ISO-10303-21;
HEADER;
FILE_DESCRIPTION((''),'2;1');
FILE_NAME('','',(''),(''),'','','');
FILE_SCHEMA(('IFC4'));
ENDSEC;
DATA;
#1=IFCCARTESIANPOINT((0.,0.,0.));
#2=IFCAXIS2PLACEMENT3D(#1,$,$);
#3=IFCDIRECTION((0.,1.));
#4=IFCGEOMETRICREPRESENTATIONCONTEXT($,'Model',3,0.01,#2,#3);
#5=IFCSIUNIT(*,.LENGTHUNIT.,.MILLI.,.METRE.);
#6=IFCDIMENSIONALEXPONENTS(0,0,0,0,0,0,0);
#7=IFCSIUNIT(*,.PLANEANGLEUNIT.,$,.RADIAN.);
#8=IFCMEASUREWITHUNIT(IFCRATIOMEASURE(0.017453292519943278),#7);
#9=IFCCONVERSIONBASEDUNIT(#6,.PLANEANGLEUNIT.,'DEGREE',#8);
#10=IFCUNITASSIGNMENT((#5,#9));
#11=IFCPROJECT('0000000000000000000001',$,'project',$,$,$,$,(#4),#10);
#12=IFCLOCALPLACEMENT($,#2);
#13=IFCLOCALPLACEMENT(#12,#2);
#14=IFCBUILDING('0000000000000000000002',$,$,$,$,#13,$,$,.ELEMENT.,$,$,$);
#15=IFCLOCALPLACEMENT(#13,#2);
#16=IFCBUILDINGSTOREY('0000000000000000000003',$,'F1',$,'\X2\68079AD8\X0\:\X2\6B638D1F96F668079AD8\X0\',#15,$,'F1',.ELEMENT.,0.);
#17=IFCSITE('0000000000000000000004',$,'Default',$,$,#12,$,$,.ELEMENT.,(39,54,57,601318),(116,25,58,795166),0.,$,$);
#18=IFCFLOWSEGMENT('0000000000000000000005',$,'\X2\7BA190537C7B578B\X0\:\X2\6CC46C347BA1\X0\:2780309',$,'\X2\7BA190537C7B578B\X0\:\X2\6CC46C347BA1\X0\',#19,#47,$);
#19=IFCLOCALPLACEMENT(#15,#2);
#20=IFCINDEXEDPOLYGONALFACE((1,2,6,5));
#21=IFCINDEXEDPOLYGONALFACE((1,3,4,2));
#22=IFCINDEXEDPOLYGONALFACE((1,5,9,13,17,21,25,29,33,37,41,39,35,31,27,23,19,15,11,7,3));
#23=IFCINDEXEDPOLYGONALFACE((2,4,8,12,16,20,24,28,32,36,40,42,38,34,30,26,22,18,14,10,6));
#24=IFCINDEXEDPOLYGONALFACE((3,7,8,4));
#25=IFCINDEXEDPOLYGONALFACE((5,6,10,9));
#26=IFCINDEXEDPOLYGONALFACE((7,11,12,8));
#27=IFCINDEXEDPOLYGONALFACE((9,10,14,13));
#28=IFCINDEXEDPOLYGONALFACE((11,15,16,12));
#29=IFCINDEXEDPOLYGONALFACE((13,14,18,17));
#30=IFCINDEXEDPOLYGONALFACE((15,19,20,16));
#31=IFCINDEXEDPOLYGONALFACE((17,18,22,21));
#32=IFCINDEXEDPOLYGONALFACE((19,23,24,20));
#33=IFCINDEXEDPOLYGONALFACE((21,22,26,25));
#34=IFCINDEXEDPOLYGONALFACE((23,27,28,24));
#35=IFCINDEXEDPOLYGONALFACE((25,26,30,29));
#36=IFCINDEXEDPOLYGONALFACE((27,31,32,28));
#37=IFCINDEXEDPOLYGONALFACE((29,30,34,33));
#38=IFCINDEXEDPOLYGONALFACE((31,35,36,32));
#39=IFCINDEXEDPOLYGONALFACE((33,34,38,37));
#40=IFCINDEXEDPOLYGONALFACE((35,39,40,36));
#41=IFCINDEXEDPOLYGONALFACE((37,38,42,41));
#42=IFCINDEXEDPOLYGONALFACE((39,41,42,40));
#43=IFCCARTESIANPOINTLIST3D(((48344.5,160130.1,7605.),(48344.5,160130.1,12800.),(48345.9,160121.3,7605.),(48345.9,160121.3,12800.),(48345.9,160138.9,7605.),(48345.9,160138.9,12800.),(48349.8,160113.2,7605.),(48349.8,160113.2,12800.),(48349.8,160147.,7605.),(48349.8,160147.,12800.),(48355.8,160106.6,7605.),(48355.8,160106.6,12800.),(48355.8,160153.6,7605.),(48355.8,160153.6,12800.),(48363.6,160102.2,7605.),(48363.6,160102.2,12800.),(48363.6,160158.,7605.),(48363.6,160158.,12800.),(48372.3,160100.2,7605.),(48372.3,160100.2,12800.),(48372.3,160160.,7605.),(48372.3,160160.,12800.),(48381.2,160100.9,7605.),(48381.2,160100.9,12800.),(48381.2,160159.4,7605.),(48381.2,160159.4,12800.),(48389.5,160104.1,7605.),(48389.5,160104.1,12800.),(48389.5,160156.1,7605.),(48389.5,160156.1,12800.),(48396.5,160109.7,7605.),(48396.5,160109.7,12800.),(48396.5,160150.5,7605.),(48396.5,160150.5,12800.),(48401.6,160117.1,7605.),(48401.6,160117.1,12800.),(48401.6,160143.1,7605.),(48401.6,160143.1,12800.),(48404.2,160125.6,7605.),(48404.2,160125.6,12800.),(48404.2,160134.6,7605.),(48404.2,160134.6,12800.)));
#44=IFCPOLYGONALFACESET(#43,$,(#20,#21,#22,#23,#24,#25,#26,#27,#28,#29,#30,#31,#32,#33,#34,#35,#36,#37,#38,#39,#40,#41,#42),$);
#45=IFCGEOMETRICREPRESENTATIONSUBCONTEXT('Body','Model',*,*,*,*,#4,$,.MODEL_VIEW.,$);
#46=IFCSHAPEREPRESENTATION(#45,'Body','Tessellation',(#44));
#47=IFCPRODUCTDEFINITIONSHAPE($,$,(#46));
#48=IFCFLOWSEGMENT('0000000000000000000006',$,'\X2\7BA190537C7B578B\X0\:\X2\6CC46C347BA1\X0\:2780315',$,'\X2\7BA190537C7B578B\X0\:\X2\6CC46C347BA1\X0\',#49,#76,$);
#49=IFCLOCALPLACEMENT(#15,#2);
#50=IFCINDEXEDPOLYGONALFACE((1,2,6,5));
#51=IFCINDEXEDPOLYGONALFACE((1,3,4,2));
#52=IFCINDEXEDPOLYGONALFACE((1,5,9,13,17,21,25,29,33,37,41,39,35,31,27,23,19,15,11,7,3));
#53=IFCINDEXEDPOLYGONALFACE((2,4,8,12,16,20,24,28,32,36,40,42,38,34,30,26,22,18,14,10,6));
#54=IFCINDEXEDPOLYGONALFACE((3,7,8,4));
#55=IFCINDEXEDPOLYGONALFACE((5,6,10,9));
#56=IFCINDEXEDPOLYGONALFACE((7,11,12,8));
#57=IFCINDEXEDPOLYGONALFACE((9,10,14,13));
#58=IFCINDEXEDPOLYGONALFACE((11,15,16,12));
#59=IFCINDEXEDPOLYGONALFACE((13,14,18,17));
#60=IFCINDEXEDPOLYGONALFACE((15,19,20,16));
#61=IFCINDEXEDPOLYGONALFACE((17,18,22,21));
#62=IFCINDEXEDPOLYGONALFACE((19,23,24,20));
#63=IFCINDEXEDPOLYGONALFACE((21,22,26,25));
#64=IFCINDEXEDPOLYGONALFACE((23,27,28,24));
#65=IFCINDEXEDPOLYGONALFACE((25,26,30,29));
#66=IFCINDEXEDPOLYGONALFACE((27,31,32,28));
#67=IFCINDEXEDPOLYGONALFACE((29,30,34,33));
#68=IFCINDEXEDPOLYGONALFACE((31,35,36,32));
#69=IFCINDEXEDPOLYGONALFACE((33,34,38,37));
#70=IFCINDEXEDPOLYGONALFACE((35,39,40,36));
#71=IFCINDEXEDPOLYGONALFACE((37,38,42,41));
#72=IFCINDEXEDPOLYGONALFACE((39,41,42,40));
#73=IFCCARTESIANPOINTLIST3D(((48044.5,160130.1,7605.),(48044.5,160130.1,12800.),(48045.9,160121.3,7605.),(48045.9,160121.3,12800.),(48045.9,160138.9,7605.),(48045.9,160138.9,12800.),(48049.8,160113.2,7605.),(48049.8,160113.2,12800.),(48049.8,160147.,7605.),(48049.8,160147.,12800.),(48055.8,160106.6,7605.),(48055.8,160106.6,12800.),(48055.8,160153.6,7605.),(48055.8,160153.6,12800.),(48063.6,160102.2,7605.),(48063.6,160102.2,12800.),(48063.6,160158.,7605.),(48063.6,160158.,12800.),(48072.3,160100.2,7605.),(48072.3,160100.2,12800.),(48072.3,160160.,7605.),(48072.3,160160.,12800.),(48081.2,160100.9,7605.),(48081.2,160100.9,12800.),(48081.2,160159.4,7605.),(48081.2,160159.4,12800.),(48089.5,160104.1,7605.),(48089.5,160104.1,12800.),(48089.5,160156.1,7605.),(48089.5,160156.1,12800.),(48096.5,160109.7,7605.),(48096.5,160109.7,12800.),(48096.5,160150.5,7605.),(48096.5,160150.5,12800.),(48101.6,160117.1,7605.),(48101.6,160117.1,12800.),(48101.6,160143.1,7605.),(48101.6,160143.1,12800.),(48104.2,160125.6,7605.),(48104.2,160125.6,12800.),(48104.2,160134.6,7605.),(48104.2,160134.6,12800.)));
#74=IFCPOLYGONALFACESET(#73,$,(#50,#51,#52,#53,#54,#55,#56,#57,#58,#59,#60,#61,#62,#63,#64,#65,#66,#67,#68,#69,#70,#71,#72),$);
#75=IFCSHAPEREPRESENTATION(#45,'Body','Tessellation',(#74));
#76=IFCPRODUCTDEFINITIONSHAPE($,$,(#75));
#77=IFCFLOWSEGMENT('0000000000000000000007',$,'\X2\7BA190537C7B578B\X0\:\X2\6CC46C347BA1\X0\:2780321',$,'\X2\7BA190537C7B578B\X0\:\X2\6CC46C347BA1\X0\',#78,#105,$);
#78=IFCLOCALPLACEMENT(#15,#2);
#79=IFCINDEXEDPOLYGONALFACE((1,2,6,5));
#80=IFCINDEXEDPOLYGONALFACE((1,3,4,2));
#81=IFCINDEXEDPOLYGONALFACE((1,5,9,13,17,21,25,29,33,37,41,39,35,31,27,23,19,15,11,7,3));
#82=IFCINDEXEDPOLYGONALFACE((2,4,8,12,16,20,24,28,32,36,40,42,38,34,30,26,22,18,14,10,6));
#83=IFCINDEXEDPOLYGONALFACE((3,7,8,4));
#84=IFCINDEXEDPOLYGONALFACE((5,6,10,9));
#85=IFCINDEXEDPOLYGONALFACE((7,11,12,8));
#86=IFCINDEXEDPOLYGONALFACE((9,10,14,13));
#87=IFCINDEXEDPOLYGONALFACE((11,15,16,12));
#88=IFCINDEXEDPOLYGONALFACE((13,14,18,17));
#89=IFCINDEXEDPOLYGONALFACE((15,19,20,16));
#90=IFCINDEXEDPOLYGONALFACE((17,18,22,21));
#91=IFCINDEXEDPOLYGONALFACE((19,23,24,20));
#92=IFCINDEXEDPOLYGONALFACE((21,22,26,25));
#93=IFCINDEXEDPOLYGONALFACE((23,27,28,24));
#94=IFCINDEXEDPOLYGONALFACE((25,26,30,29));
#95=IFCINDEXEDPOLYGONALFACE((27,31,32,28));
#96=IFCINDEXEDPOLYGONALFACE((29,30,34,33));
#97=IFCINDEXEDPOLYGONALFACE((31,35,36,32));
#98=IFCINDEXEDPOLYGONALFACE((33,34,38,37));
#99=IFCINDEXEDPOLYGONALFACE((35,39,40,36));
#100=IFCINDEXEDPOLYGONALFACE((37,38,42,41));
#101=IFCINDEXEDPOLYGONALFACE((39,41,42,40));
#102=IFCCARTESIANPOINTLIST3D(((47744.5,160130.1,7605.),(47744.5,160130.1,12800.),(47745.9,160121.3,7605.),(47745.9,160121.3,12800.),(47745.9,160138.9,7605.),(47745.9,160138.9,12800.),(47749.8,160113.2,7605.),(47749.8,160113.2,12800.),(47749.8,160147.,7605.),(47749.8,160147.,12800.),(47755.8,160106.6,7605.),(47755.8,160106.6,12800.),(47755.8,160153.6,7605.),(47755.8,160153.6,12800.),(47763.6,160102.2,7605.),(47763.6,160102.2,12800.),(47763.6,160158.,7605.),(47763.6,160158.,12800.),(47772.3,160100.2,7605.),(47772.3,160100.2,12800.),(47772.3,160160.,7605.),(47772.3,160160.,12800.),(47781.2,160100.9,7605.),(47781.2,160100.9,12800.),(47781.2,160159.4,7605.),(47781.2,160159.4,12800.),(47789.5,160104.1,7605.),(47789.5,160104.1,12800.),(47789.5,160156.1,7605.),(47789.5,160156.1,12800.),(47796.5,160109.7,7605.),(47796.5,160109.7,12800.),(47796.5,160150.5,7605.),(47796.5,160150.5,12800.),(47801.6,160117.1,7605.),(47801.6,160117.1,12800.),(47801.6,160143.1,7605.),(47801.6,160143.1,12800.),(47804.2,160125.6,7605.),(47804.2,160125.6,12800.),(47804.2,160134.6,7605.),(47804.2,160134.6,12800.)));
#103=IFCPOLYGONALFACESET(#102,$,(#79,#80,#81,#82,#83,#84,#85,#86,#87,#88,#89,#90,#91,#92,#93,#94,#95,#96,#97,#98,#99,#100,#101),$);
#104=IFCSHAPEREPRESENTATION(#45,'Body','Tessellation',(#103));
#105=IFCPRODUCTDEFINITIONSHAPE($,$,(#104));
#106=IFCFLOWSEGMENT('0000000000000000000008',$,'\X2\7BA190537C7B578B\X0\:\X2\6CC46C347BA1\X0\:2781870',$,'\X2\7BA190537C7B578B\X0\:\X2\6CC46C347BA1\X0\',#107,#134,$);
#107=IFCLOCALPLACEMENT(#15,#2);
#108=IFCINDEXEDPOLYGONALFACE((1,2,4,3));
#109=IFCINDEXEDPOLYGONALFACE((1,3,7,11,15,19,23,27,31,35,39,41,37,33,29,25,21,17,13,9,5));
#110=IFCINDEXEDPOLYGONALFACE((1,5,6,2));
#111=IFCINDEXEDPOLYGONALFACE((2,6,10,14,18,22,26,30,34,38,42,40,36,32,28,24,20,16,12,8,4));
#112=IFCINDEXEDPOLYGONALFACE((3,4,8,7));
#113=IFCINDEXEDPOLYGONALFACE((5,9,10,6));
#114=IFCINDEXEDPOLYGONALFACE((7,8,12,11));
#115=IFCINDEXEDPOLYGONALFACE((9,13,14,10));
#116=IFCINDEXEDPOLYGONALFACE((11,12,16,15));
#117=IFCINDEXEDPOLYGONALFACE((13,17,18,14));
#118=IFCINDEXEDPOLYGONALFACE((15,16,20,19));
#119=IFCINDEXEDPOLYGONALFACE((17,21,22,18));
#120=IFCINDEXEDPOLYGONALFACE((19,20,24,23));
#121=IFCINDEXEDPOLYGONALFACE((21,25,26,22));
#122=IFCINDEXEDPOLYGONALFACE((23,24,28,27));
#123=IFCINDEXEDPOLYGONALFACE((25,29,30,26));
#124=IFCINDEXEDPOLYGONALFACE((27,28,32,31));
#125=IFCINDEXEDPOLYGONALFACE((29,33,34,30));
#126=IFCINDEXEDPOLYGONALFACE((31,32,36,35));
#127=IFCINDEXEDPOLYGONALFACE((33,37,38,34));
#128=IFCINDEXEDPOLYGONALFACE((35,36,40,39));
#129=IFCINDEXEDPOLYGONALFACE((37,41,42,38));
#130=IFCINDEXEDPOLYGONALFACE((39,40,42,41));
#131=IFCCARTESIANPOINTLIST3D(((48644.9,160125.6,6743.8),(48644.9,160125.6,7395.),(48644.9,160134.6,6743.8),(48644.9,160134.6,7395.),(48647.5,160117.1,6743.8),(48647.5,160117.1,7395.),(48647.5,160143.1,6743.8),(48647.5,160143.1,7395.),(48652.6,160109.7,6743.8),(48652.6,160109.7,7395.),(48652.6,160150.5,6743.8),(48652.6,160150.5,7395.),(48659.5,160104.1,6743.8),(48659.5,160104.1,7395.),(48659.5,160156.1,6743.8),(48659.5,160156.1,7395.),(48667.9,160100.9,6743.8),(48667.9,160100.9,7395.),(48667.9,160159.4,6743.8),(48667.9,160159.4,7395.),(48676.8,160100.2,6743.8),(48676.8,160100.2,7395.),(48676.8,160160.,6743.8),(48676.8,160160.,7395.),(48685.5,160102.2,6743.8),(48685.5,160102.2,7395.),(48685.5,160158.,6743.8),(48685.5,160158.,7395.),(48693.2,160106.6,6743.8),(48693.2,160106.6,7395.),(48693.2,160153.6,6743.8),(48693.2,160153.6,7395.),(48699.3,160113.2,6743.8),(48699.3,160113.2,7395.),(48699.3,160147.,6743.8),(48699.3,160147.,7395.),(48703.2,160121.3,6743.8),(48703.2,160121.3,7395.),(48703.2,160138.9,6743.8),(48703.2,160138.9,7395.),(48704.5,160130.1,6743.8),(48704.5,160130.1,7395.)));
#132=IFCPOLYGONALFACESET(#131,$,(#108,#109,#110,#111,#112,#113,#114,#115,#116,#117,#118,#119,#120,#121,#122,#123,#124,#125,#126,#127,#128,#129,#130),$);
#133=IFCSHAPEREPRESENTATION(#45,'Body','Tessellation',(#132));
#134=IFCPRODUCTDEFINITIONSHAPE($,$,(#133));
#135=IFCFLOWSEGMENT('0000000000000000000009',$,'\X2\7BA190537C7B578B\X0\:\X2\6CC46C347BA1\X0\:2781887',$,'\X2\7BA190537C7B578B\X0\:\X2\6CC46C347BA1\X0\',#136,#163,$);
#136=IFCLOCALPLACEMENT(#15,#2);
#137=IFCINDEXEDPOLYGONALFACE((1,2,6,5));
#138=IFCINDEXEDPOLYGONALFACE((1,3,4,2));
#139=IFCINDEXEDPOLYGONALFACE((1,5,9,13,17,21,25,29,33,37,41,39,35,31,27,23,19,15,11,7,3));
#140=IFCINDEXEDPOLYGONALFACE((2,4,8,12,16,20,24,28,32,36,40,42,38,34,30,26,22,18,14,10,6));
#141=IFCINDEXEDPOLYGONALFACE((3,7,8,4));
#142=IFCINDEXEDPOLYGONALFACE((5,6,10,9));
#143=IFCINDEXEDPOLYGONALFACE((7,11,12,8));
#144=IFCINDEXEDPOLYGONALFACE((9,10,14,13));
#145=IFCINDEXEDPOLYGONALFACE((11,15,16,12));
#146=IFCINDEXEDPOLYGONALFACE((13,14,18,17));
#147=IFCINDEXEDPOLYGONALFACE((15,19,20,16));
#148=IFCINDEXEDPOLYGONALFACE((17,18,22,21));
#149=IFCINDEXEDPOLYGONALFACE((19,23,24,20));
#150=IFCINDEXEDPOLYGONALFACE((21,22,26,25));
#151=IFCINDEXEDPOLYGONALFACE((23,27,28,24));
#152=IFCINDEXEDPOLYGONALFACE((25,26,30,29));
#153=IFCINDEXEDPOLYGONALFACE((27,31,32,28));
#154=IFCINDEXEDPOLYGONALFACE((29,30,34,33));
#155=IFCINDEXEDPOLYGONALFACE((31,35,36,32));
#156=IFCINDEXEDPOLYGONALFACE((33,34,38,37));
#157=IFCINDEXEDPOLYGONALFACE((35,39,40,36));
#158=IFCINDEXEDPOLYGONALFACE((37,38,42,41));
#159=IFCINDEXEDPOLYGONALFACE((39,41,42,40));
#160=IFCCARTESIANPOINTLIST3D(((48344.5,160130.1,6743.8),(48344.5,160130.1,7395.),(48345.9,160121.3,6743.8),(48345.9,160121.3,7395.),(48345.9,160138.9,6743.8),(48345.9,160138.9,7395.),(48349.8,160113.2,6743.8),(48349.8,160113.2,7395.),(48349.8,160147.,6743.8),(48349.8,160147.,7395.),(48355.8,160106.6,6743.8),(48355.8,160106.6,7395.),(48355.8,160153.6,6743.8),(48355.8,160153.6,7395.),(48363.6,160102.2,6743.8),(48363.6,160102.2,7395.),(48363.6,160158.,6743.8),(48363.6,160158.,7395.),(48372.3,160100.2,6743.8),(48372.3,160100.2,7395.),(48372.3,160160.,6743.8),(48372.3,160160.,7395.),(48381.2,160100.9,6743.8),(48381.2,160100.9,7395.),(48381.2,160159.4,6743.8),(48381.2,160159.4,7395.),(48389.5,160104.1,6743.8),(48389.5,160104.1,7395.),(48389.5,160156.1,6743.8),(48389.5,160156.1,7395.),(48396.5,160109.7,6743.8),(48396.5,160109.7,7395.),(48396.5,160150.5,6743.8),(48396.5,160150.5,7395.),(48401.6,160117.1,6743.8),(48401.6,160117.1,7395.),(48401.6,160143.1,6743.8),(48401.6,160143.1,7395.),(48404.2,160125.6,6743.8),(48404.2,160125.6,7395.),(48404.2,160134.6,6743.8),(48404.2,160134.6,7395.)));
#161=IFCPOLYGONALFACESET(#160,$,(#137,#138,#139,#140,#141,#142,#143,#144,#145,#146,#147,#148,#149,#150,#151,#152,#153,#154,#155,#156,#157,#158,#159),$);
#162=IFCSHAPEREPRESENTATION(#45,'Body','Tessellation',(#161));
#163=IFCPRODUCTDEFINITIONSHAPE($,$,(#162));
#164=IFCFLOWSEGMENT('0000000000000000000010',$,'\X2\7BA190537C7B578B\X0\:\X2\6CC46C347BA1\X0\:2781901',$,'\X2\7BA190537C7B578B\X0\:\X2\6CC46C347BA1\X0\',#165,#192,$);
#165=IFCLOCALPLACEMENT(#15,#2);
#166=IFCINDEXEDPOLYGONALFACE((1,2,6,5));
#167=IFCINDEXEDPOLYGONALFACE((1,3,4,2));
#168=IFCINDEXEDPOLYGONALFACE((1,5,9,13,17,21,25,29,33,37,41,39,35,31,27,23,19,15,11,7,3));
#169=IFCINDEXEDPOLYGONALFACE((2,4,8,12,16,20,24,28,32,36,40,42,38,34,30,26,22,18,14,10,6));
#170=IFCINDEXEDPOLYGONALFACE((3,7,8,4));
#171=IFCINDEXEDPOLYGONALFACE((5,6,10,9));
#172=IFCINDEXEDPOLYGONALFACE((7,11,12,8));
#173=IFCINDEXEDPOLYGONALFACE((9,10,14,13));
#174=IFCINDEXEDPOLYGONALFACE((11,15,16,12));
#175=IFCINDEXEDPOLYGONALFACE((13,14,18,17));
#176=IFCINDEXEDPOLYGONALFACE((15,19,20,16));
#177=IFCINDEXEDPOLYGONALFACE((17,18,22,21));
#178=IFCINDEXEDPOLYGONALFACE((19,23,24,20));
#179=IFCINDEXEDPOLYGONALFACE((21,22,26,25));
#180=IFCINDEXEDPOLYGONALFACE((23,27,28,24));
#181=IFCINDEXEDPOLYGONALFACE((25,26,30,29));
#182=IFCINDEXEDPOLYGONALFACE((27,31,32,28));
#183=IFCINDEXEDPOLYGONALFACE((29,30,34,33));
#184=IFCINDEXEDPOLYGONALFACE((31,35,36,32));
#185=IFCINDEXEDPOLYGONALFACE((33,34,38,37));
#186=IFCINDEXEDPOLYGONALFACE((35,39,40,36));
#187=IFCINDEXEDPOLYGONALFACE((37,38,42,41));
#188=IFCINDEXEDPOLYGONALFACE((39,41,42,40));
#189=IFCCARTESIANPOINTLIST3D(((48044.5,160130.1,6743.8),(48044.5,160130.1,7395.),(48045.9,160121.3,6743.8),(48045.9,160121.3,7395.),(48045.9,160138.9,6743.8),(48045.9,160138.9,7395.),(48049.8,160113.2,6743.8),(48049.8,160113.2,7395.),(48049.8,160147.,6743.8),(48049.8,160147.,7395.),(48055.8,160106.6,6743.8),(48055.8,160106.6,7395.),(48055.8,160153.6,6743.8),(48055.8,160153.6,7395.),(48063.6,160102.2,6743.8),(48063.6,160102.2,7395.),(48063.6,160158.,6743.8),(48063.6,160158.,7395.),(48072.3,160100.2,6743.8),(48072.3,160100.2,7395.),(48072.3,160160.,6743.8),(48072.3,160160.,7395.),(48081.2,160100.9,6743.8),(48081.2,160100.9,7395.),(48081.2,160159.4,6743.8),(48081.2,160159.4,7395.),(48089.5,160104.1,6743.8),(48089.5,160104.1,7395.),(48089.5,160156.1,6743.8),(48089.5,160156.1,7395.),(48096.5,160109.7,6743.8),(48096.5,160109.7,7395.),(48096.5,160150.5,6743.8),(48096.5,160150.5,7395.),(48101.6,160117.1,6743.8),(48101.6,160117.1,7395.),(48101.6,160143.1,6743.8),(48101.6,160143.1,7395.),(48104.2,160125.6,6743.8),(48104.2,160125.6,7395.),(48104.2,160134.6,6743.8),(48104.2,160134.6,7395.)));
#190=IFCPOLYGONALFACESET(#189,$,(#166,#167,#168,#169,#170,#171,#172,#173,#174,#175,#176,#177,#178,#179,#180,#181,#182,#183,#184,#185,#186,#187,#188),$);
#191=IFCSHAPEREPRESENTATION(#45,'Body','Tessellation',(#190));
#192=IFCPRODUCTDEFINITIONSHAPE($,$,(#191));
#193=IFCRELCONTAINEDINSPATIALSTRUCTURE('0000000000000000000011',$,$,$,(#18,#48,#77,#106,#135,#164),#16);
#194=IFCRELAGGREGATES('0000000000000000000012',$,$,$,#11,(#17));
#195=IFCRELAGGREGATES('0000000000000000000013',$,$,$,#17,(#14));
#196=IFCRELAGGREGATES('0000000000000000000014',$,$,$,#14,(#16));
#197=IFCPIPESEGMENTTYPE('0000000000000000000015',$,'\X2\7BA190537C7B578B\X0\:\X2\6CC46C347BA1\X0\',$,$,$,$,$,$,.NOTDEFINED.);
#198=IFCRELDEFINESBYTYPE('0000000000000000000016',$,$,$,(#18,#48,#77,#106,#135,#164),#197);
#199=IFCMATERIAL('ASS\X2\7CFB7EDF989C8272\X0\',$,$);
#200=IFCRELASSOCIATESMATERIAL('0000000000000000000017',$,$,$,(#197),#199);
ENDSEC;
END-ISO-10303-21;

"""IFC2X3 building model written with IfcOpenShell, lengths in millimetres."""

from ifc_helpers import new_model, entity, si_unit, converted_unit, direction, frame, frame_2d, origin, origin_2d_with_axis, place, context, subcontext, project, spatial, circle, extrude, material, type_object, element, save


model = new_model("IFC2X3")

# Units and contexts
model_context = context("Model", 3, precision=0.01, world=origin(), true_north=direction((0.0, 1.0)))
body_context = subcontext(model_context, "Body", "Model", "MODEL_VIEW")
ifc_project = project(units=[si_unit("LENGTHUNIT", "METRE", prefix="MILLI"), converted_unit("PLANEANGLEUNIT", "DEGREE", entity("IfcRatioMeasure", 0.017453292519943278), si_unit("PLANEANGLEUNIT", "RADIAN"), dimensions=[0, 0, 0, 0, 0, 0, 0])], contexts=[model_context])

# Site, building, storey
site_placement = place(None, origin())
site = spatial("IfcSite", under=ifc_project, at=site_placement, Name="Default", CompositionType="ELEMENT", RefLatitude=(39, 54, 57, 601318), RefLongitude=(116, 25, 58, 795166), RefElevation=0.0)
building_placement = place(site_placement, origin())
building = spatial("IfcBuilding", under=site, at=building_placement, CompositionType="ELEMENT")
storey_placement = place(building_placement, origin())
storey = spatial("IfcBuildingStorey", under=building, at=storey_placement, Name="F1", ObjectType="标高:正负零标高", LongName="F1", CompositionType="ELEMENT", Elevation=0.0)

# Flow segments
ifc_material_1 = material(Name="ASS系统颜色")
pipe_segment_type_1 = type_object("IfcPipeSegmentType", Name="管道类型:泄水管", PredefinedType="NOTDEFINED", material=ifc_material_1)
flow_segment_1_placement = place(storey_placement, origin())
element("IfcFlowSegment", 1, at=flow_segment_1_placement, inside=storey, type_object=pipe_segment_type_1, Name="管道类型:泄水管:2780309", ObjectType="管道类型:泄水管", context=body_context, shape_type="SweptSolid", body=[
    extrude(circle(Radius=30.0, at=frame_2d((0.0, 0.0), x_axis=(1.0, 0.0))), frame((48374.5, 160130.1, 7605.0), z_axis=(0.0, 0.0, 1.0), x_axis=(-1.0, 0.0, 0.0)), (0.0, 0.0, 1.0), 5195.0),
])
flow_segment_2_placement = place(storey_placement, origin())
element("IfcFlowSegment", 2, at=flow_segment_2_placement, inside=storey, type_object=pipe_segment_type_1, Name="管道类型:泄水管:2780315", ObjectType="管道类型:泄水管", context=body_context, shape_type="SweptSolid", body=[
    extrude(circle(Radius=30.0, at=frame_2d((0.0, 0.0), x_axis=(1.0, 0.0))), frame((48074.5, 160130.1, 7605.0), z_axis=(0.0, 0.0, 1.0), x_axis=(-1.0, 0.0, 0.0)), (0.0, 0.0, 1.0), 5195.0),
])
flow_segment_3_placement = place(storey_placement, origin())
element("IfcFlowSegment", 3, at=flow_segment_3_placement, inside=storey, type_object=pipe_segment_type_1, Name="管道类型:泄水管:2780321", ObjectType="管道类型:泄水管", context=body_context, shape_type="SweptSolid", body=[
    extrude(circle(Radius=30.0, at=frame_2d((0.0, 0.0), x_axis=(1.0, 0.0))), frame((47774.5, 160130.1, 7605.0), z_axis=(0.0, 0.0, 1.0), x_axis=(-1.0, 0.0, 0.0)), (0.0, 0.0, 1.0), 5195.0),
])
flow_segment_4_placement = place(storey_placement, origin())
element("IfcFlowSegment", 4, at=flow_segment_4_placement, inside=storey, type_object=pipe_segment_type_1, Name="管道类型:泄水管:2781870", ObjectType="管道类型:泄水管", context=body_context, shape_type="SweptSolid", body=[
    extrude(circle(Radius=30.0, at=origin_2d_with_axis()), frame((48674.5, 160130.1, 6743.8)), (0.0, 0.0, 1.0), 651.2),
])
flow_segment_5_placement = place(storey_placement, origin())
element("IfcFlowSegment", 5, at=flow_segment_5_placement, inside=storey, type_object=pipe_segment_type_1, Name="管道类型:泄水管:2781887", ObjectType="管道类型:泄水管", context=body_context, shape_type="SweptSolid", body=[
    extrude(circle(Radius=30.0, at=frame_2d((0.0, 0.0), x_axis=(1.0, 0.0))), frame((48374.5, 160130.1, 6743.8), z_axis=(0.0, 0.0, 1.0), x_axis=(-1.0, 0.0, 0.0)), (0.0, 0.0, 1.0), 651.2),
])
flow_segment_6_placement = place(storey_placement, origin())
element("IfcFlowSegment", 6, at=flow_segment_6_placement, inside=storey, type_object=pipe_segment_type_1, Name="管道类型:泄水管:2781901", ObjectType="管道类型:泄水管", context=body_context, shape_type="SweptSolid", body=[
    extrude(circle(Radius=30.0, at=frame_2d((0.0, 0.0), x_axis=(1.0, 0.0))), frame((48074.5, 160130.1, 6743.8), z_axis=(0.0, 0.0, 1.0), x_axis=(-1.0, 0.0, 0.0)), (0.0, 0.0, 1.0), 651.2),
])

save(model, "model.ifc")
